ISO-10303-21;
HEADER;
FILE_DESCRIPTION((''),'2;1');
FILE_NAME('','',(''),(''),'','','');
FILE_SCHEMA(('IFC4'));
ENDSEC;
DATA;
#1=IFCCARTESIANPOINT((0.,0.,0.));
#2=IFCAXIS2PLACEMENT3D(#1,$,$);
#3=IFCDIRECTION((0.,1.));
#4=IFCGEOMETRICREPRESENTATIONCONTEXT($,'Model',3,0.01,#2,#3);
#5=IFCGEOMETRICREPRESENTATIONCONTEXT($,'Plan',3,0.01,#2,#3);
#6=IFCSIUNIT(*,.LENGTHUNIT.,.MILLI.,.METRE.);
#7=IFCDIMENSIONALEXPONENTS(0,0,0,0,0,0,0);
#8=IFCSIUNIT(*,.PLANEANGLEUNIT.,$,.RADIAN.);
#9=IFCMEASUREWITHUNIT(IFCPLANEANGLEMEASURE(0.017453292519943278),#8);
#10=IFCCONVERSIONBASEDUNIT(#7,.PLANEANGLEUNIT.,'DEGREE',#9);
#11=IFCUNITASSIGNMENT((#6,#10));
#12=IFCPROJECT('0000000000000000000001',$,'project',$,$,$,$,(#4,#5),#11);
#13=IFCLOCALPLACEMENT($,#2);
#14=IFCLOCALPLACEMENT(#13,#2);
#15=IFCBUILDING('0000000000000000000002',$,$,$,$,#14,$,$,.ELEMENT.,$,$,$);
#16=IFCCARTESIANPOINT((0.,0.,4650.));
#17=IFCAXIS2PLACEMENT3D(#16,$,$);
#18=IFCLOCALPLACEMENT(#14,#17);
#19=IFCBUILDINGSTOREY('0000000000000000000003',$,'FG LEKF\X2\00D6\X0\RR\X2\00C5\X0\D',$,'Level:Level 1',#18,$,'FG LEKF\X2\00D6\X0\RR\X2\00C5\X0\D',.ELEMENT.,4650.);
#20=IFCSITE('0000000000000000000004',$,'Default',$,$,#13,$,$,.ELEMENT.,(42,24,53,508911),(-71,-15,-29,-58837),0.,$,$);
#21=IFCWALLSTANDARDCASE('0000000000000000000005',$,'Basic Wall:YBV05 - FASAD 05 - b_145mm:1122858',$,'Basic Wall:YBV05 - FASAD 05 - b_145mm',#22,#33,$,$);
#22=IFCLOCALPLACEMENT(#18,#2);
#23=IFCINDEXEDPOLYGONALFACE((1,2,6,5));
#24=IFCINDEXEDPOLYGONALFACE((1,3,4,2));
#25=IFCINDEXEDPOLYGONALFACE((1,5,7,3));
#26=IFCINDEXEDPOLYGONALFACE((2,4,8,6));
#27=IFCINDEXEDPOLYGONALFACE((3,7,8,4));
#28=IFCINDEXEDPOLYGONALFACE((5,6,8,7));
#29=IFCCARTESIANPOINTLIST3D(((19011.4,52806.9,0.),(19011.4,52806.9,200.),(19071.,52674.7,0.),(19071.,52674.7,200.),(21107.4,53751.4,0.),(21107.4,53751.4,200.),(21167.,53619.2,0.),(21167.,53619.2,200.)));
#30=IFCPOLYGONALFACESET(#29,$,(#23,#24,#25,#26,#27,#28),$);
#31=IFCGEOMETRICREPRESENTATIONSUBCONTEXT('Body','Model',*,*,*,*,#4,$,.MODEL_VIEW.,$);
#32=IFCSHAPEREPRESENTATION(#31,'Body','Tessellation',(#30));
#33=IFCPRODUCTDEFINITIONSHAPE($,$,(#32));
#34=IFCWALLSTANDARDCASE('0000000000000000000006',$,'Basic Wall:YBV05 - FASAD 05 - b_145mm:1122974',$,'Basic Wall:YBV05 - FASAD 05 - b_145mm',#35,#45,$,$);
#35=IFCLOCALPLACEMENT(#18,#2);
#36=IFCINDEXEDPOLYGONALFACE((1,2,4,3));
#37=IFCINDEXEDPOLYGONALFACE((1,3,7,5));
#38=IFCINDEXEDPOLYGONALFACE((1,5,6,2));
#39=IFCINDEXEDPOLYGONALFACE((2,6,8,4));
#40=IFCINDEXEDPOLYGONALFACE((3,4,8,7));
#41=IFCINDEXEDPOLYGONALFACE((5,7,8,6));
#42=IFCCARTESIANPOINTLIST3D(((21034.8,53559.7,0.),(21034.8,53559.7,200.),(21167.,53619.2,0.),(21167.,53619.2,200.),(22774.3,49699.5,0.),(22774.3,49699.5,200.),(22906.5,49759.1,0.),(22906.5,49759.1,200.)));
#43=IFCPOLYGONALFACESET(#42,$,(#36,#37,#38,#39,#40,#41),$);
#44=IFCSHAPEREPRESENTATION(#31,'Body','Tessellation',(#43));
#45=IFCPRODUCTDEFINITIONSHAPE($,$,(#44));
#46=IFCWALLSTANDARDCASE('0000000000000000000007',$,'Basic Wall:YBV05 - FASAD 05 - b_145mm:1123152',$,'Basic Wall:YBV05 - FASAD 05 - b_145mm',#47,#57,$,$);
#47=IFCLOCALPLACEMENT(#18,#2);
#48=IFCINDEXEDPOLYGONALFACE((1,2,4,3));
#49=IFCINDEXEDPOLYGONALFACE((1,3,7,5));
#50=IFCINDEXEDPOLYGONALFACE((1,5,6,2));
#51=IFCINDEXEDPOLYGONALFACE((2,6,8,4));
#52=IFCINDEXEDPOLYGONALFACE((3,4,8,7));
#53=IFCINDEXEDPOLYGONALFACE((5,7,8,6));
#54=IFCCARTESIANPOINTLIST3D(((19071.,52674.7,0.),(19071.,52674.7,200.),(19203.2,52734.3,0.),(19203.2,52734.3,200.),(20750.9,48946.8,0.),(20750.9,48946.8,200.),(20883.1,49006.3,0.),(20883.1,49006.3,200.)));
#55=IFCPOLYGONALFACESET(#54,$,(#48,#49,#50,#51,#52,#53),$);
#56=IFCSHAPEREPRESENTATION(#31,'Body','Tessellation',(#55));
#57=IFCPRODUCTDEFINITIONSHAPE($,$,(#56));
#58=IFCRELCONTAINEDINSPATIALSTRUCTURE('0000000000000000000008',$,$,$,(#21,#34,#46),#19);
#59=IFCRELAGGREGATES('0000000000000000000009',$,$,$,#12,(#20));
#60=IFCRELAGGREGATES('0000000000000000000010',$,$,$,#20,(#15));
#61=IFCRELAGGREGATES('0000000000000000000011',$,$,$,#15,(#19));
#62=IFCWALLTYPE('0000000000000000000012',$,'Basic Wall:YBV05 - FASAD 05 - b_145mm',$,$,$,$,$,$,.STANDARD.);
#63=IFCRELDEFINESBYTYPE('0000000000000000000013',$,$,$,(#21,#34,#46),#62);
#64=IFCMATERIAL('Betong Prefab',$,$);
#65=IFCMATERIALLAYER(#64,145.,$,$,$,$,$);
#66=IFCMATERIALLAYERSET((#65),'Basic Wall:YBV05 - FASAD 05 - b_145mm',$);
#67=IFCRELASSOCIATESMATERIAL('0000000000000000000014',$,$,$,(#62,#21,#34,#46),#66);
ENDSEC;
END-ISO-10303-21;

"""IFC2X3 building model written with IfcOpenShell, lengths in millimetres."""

from ifc_helpers import new_model, entity, si_unit, converted_unit, direction, frame, frame_2d, origin, place, context, subcontext, project, spatial, rectangle, extrude, material, layer, layer_set, layer_usage, type_object, element, save


model = new_model("IFC2X3")

# Units and contexts
model_context = context("Model", 3, precision=0.01, world=origin(), true_north=direction((0.0, 1.0)))
plan_context = context("Plan", 3, precision=0.01, world=origin(), true_north=direction((0.0, 1.0)))
body_context = subcontext(model_context, "Body", "Model", "MODEL_VIEW")
ifc_project = project(units=[si_unit("LENGTHUNIT", "METRE", prefix="MILLI"), converted_unit("PLANEANGLEUNIT", "DEGREE", entity("IfcPlaneAngleMeasure", 0.017453292519943278), si_unit("PLANEANGLEUNIT", "RADIAN"), dimensions=[0, 0, 0, 0, 0, 0, 0])], contexts=[model_context, plan_context])

# Site, building, storey
site_placement = place(None, origin())
site = spatial("IfcSite", under=ifc_project, at=site_placement, Name="Default", CompositionType="ELEMENT", RefLatitude=(42, 24, 53, 508911), RefLongitude=(-71, -15, -29, -58837), RefElevation=0.0)
building_placement = place(site_placement, origin())
building = spatial("IfcBuilding", under=site, at=building_placement, CompositionType="ELEMENT")
storey_placement = place(building_placement, frame((0.0, 0.0, 4650.0)))
storey = spatial("IfcBuildingStorey", under=building, at=storey_placement, Name="FG LEKFÖRRÅD", ObjectType="Level:Level 1", LongName="FG LEKFÖRRÅD", CompositionType="ELEMENT", Elevation=4650.0)

# Walls
ifc_material_1 = material(Name="Betong Prefab")
ifc_layer_1 = layer(ifc_material_1, 145.0)
ifc_layer_set_1 = layer_set([ifc_layer_1], Name="Basic Wall:YBV05 - FASAD 05 - b_145mm")
ifc_layer_usage_1 = layer_usage(ifc_layer_set_1, "AXIS2", "NEGATIVE", 72.5)
wall_type_1 = type_object("IfcWallType", Name="Basic Wall:YBV05 - FASAD 05 - b_145mm", PredefinedType="STANDARD", material=ifc_layer_set_1)
wall_1_placement = place(storey_placement, frame((19041.2, 52740.8, 0.0), z_axis=(0.0, 0.0, 1.0), x_axis=(0.911709, 0.410836, 0.0)))
element("IfcWallStandardCase", 1, at=wall_1_placement, inside=storey, type_object=wall_type_1, material=ifc_layer_usage_1, Name="Basic Wall:YBV05 - FASAD 05 - b_145mm:1122858", ObjectType="Basic Wall:YBV05 - FASAD 05 - b_145mm", context=body_context, shape_type="SweptSolid", body=[
    extrude(rectangle(XDim=2299.0, YDim=145.0, at=frame_2d((1149.5, 0.0), x_axis=(-1.0, 0.0))), origin(), (0.0, 0.0, 1.0), 200.0),
])
ifc_layer_usage_2 = layer_usage(ifc_layer_set_1, "AXIS2", "NEGATIVE", 72.5)
wall_2_placement = place(storey_placement, frame((21100.9, 53589.5, 0.0), z_axis=(0.0, 0.0, 1.0), x_axis=(0.410836, -0.911709, 0.0)))
element("IfcWallStandardCase", 2, at=wall_2_placement, inside=storey, type_object=wall_type_1, material=ifc_layer_usage_2, Name="Basic Wall:YBV05 - FASAD 05 - b_145mm:1122974", ObjectType="Basic Wall:YBV05 - FASAD 05 - b_145mm", context=body_context, shape_type="SweptSolid", body=[
    extrude(rectangle(XDim=4234.0, YDim=145.0, at=frame_2d((2117.0, 0.0), x_axis=(-1.0, 0.0))), origin(), (0.0, 0.0, 1.0), 200.0),
])

# Wall
ifc_layer_usage_3 = layer_usage(ifc_layer_set_1, "AXIS2", "NEGATIVE", 72.5)
wall_3_placement = place(storey_placement, frame((20817.0, 48976.5, 0.0), z_axis=(0.0, 0.0, 1.0), x_axis=(-0.410836, 0.911709, 0.0)))
element("IfcWallStandardCase", 3, at=wall_3_placement, inside=storey, type_object=wall_type_1, material=ifc_layer_usage_3, Name="Basic Wall:YBV05 - FASAD 05 - b_145mm:1123152", ObjectType="Basic Wall:YBV05 - FASAD 05 - b_145mm", context=body_context, shape_type="SweptSolid", body=[
    extrude(rectangle(XDim=4089.0, YDim=145.0, at=frame_2d((2044.5, 0.0), x_axis=(-1.0, 0.0))), origin(), (0.0, 0.0, 1.0), 200.0),
])

save(model, "model.ifc")
